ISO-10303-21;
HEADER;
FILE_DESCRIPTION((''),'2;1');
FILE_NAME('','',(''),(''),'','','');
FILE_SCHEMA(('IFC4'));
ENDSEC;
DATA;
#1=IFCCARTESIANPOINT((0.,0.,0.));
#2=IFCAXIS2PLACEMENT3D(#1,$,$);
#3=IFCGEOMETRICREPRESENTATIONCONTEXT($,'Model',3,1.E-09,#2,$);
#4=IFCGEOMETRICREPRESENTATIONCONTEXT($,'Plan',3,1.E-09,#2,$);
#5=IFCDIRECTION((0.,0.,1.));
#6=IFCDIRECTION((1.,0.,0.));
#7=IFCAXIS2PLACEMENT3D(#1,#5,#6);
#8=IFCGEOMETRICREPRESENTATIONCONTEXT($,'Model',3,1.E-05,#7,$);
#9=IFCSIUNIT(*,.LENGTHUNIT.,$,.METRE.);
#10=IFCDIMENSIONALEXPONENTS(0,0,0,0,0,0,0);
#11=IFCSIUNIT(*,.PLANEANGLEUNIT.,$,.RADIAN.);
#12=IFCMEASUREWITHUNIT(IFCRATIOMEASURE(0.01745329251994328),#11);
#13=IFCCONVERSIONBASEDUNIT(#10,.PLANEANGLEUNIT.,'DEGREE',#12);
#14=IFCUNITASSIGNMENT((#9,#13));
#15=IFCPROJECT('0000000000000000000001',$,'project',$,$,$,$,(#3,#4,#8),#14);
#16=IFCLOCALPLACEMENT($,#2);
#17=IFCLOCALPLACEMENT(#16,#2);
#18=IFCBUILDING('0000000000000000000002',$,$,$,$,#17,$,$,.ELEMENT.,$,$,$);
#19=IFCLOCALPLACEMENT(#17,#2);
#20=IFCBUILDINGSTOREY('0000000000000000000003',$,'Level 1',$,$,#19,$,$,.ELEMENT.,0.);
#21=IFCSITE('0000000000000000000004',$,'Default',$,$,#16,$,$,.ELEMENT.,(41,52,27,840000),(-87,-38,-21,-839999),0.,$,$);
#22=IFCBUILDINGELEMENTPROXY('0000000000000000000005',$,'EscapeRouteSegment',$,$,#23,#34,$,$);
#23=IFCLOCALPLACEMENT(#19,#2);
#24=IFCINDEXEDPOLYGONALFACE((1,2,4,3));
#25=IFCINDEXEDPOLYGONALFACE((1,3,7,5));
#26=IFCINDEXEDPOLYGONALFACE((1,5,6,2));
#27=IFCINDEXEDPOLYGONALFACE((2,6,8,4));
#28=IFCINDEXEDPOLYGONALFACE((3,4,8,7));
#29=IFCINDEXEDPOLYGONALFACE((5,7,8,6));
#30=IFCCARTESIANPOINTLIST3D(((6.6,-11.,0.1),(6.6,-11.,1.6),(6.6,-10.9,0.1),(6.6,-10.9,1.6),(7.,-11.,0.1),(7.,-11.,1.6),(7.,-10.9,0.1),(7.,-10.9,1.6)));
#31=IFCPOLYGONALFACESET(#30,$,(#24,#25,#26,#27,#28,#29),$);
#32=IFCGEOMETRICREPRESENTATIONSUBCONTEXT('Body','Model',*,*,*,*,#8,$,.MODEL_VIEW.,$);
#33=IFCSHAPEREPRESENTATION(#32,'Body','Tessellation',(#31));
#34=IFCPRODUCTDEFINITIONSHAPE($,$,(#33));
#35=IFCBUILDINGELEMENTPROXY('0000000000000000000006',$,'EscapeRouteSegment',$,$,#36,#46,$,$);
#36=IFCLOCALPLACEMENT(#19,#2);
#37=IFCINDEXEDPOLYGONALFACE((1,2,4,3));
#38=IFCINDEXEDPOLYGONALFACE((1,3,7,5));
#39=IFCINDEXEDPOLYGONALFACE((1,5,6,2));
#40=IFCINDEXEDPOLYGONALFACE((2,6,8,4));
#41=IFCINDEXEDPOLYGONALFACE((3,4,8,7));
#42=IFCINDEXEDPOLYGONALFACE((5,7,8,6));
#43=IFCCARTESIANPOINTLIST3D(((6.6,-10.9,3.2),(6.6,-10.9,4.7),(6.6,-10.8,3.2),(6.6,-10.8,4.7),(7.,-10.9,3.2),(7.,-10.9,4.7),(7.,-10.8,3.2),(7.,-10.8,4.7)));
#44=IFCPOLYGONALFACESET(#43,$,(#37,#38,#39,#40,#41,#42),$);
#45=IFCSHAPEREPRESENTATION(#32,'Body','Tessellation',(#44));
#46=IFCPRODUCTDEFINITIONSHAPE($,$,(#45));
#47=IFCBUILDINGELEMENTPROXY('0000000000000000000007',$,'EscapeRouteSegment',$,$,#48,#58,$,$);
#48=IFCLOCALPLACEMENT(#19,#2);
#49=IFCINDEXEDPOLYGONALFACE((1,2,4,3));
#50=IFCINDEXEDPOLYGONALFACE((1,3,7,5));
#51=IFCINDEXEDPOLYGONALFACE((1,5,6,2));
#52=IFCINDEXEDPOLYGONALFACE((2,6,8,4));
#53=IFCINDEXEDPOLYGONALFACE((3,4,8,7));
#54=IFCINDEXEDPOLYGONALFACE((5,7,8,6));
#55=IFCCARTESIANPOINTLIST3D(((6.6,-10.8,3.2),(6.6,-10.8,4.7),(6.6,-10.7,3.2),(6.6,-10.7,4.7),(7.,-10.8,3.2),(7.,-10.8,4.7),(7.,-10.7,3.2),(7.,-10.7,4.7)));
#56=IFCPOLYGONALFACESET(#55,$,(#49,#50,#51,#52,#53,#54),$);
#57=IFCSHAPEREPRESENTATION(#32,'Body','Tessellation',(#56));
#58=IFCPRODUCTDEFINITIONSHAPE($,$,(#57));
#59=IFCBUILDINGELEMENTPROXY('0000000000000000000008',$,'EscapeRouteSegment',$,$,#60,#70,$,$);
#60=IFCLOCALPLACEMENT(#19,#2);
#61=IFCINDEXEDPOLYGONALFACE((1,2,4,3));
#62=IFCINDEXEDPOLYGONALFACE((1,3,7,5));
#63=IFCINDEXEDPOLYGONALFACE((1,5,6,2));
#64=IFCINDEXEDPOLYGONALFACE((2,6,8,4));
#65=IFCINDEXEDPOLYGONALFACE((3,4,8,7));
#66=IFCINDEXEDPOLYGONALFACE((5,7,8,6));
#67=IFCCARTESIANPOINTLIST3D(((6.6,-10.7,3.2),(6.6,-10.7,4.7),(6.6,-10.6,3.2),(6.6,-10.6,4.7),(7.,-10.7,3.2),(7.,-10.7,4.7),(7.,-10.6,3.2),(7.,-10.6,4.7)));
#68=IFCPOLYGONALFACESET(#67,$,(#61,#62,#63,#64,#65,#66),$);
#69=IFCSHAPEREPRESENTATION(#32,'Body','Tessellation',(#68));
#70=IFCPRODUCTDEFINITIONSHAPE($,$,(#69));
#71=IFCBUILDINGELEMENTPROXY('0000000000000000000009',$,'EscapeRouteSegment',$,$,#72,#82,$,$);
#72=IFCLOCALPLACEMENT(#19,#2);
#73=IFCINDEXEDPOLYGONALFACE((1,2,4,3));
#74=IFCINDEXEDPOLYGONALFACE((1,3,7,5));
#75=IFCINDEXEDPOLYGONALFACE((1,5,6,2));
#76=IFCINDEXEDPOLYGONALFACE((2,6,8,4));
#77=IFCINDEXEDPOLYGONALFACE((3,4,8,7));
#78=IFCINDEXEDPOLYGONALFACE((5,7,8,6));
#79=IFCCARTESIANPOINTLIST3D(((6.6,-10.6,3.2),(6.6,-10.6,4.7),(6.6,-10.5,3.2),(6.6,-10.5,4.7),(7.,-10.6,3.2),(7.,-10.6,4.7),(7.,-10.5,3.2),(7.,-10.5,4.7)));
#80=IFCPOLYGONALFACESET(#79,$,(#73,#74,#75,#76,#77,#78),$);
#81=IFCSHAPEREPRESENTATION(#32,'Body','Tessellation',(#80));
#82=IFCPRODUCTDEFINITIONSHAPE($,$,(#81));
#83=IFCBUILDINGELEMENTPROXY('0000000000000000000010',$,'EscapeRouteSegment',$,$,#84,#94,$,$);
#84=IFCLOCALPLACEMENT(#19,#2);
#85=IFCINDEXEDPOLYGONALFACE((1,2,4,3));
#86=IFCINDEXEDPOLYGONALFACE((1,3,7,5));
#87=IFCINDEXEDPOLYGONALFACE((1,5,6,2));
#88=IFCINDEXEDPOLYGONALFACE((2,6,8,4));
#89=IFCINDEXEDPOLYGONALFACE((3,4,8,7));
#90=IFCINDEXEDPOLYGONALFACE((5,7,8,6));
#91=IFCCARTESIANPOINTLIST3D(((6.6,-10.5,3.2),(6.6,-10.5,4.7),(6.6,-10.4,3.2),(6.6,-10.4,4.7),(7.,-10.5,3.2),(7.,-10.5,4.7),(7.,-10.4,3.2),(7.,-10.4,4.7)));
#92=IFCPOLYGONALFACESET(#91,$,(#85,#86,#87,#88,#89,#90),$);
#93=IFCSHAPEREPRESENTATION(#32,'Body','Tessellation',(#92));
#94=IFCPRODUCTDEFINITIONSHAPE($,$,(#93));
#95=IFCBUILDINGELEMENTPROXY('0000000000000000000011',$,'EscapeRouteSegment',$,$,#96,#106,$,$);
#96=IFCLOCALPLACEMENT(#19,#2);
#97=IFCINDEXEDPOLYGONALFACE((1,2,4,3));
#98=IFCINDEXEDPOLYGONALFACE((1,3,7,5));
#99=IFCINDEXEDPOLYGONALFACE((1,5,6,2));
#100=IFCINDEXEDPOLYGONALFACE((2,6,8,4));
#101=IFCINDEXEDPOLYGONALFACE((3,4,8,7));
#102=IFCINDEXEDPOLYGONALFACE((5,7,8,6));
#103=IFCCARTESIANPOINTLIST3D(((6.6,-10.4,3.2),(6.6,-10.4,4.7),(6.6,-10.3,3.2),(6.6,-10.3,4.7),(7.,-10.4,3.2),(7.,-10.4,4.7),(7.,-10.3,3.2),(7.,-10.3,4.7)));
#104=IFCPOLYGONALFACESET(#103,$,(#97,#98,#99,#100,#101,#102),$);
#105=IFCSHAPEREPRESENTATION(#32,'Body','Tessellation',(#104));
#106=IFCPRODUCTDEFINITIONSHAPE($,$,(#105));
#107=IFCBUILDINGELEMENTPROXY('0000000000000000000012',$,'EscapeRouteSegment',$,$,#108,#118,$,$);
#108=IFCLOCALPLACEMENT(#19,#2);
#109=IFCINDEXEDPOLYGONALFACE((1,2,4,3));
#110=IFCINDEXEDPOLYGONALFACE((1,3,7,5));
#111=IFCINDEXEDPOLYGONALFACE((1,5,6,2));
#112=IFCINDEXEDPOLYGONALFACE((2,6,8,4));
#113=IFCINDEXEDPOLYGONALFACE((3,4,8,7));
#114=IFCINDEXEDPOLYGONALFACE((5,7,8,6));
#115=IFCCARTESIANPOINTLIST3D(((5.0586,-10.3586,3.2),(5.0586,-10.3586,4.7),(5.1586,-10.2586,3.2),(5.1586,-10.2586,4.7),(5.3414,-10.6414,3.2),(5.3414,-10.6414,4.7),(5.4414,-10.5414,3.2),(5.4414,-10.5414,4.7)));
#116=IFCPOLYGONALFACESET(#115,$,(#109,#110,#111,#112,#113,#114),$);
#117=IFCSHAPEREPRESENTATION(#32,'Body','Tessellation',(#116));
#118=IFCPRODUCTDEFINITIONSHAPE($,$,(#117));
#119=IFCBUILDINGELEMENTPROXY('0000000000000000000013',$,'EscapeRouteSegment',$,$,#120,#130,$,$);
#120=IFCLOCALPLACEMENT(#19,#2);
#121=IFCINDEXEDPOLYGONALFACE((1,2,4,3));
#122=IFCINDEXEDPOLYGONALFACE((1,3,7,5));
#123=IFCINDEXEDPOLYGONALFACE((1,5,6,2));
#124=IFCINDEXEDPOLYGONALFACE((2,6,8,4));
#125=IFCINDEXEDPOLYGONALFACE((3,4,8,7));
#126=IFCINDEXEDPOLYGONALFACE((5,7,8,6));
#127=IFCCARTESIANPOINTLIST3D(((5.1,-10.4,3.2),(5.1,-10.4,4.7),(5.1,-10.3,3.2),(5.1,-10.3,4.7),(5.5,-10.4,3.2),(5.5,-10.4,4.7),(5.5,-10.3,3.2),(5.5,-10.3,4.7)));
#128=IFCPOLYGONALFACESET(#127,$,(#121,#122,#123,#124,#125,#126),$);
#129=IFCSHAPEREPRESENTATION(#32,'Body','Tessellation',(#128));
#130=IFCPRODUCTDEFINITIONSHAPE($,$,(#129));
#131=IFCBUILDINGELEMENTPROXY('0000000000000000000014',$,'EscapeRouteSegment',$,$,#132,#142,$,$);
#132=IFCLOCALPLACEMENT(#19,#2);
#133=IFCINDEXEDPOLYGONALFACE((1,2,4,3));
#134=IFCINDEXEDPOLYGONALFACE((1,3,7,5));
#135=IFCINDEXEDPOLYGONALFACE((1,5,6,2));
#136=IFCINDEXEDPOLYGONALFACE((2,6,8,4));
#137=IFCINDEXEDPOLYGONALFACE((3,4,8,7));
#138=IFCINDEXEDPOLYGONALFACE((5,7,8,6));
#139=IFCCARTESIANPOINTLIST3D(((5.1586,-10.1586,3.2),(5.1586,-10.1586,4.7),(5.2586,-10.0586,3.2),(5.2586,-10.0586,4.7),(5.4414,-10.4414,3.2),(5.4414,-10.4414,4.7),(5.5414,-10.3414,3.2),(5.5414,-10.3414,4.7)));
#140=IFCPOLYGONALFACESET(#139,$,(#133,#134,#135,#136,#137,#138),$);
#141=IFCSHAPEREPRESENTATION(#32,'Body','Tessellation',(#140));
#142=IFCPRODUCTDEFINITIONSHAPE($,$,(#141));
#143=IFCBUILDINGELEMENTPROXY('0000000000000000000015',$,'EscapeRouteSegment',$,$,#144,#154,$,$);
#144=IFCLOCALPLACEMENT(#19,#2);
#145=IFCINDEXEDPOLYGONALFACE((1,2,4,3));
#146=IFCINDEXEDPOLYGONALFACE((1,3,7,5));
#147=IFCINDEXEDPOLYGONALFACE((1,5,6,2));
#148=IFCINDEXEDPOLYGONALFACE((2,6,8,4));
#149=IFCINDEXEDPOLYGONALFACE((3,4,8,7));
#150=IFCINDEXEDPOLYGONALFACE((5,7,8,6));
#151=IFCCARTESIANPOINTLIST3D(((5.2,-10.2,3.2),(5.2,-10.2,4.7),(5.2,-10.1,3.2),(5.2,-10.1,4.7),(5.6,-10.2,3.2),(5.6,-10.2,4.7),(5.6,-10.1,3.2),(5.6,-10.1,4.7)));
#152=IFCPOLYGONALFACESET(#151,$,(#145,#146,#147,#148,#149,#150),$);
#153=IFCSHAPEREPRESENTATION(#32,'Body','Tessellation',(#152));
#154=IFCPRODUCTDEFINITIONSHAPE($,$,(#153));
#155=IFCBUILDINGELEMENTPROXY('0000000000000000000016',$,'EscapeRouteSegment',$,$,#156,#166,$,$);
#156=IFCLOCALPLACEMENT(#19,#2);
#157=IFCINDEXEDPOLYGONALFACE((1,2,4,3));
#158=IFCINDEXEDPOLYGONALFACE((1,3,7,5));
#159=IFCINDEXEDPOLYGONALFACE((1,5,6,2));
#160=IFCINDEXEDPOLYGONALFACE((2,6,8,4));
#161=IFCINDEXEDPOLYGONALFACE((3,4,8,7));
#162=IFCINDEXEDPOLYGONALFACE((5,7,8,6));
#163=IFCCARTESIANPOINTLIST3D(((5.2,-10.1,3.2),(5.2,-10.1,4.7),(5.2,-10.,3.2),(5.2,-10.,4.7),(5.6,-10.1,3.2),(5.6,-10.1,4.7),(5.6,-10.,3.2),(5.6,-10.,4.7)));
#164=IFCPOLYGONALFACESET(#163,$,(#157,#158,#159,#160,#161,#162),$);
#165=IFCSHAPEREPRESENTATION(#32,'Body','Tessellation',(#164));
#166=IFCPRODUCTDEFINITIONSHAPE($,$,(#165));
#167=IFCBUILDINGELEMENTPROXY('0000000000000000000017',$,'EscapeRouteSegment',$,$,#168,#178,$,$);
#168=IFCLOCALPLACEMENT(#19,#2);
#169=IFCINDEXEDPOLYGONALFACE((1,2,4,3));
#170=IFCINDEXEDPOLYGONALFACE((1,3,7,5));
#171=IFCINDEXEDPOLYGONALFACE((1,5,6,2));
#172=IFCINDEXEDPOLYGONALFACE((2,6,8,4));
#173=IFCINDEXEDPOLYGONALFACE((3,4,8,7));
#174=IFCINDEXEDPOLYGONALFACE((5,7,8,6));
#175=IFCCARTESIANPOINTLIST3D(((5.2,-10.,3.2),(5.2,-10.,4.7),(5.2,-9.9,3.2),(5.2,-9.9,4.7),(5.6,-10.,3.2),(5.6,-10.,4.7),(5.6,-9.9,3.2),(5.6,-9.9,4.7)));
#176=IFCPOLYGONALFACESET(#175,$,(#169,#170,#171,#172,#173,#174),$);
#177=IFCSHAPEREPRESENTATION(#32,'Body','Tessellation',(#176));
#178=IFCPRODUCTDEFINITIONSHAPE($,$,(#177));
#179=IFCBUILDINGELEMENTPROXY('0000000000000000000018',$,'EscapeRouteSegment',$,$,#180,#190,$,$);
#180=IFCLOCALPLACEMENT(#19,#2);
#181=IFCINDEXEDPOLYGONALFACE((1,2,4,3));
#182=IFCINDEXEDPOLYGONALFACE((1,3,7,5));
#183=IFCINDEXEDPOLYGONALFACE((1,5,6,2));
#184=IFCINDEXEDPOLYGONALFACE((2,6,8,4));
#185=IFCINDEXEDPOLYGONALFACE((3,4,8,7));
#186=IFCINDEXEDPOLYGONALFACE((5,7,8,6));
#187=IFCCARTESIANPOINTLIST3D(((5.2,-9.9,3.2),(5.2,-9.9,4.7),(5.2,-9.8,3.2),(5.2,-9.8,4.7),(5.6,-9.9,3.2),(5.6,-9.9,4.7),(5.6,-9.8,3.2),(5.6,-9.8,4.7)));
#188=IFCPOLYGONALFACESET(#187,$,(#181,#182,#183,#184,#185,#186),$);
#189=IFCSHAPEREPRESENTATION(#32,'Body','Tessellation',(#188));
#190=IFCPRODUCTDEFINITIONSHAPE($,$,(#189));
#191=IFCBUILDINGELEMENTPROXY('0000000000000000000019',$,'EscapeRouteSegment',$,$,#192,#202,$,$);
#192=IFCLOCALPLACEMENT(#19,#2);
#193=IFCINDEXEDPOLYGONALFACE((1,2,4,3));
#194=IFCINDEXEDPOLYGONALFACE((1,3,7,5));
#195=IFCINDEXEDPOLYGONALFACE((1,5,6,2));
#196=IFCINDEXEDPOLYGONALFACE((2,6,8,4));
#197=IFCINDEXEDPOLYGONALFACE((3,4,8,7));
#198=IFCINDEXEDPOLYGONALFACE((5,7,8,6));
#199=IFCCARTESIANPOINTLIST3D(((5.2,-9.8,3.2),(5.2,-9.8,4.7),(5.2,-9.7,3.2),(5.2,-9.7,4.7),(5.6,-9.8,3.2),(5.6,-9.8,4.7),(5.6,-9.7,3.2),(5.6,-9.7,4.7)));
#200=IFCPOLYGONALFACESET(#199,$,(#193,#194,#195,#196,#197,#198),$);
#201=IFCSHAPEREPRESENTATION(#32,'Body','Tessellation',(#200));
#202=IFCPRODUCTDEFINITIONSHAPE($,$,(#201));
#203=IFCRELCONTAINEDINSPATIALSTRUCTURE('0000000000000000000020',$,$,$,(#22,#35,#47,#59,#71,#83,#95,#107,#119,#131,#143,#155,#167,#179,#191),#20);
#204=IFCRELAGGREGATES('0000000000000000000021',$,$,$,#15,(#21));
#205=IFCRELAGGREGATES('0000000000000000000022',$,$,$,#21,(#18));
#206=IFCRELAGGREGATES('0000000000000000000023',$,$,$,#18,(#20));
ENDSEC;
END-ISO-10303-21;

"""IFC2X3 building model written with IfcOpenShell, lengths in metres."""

from ifc_helpers import new_model, entity, si_unit, converted_unit, frame, origin, origin_with_axes, place, context, subcontext, project, spatial, polyline, outline, extrude, element, save


model = new_model("IFC2X3")

# Units and contexts
model_context_1 = context("Model", 3, precision=1e-09, world=origin())
plan_context = context("Plan", 3, precision=1e-09, world=origin())
model_context_2 = context("Model", 3, precision=1e-05, world=origin_with_axes())
body_context = subcontext(model_context_2, "Body", "Model", "MODEL_VIEW")
ifc_project = project(units=[si_unit("LENGTHUNIT", "METRE"), converted_unit("PLANEANGLEUNIT", "DEGREE", entity("IfcRatioMeasure", 0.01745329251994328), si_unit("PLANEANGLEUNIT", "RADIAN"), dimensions=[0, 0, 0, 0, 0, 0, 0])], contexts=[model_context_1, plan_context, model_context_2])

# Site, building, storey
site_placement = place(None, origin())
site = spatial("IfcSite", under=ifc_project, at=site_placement, Name="Default", CompositionType="ELEMENT", RefLatitude=(41, 52, 27, 840000), RefLongitude=(-87, -38, -21, -839999), RefElevation=0.0)
building_placement = place(site_placement, origin())
building = spatial("IfcBuilding", under=site, at=building_placement, CompositionType="ELEMENT")
storey_placement = place(building_placement, origin())
storey = spatial("IfcBuildingStorey", under=building, at=storey_placement, Name="Level 1", CompositionType="ELEMENT", Elevation=0.0)

# Building element proxies
proxy_1_placement = place(storey_placement, frame((6.8, -10.9, 0.1), z_axis=(0.0, 0.0, 1.0), x_axis=(0.0, -1.0, 0.0)))
element("IfcBuildingElementProxy", 1, at=proxy_1_placement, inside=storey, Name="EscapeRouteSegment", context=body_context, shape_type="SweptSolid", body=[
    extrude(outline(polyline([(0.0, -0.2), (0.0, 0.2), (0.1, 0.2), (0.1, -0.2), (0.0, -0.2)])), origin_with_axes(), (0.0, 0.0, 1.0), 1.5),
])
proxy_2_placement = place(storey_placement, frame((6.8, -10.9, 3.2), z_axis=(0.0, 0.0, 1.0), x_axis=(0.0, 1.0, 0.0)))
element("IfcBuildingElementProxy", 2, at=proxy_2_placement, inside=storey, Name="EscapeRouteSegment", context=body_context, shape_type="SweptSolid", body=[
    extrude(outline(polyline([(0.0, -0.2), (0.0, 0.2), (0.1, 0.2), (0.1, -0.2), (0.0, -0.2)])), origin_with_axes(), (0.0, 0.0, 1.0), 1.5),
])
proxy_3_placement = place(storey_placement, frame((6.8, -10.8, 3.2), z_axis=(0.0, 0.0, 1.0), x_axis=(0.0, 1.0, 0.0)))
element("IfcBuildingElementProxy", 3, at=proxy_3_placement, inside=storey, Name="EscapeRouteSegment", context=body_context, shape_type="SweptSolid", body=[
    extrude(outline(polyline([(0.0, -0.2), (0.0, 0.2), (0.1, 0.2), (0.1, -0.2), (0.0, -0.2)])), origin_with_axes(), (0.0, 0.0, 1.0), 1.5),
])
proxy_4_placement = place(storey_placement, frame((6.8, -10.7, 3.2), z_axis=(0.0, 0.0, 1.0), x_axis=(0.0, 1.0, 0.0)))
element("IfcBuildingElementProxy", 4, at=proxy_4_placement, inside=storey, Name="EscapeRouteSegment", context=body_context, shape_type="SweptSolid", body=[
    extrude(outline(polyline([(0.0, -0.2), (0.0, 0.2), (0.1, 0.2), (0.1, -0.2), (0.0, -0.2)])), origin_with_axes(), (0.0, 0.0, 1.0), 1.5),
])
for number, where, z_axis, x_axis, name in (
    (5, (6.8, -10.6, 3.2), (0.0, 0.0, 1.0), (0.0, 1.0, 0.0), "EscapeRouteSegment"),
    (6, (6.8, -10.5, 3.2), (0.0, 0.0, 1.0), (0.0, 1.0, 0.0), "EscapeRouteSegment"),
):
    element("IfcBuildingElementProxy", number, at=place(storey_placement, frame(where, z_axis=z_axis, x_axis=x_axis)), inside=storey, Name=name, context=body_context, shape_type="SweptSolid", body=[
        extrude(outline(polyline([(0.0, -0.2), (0.0, 0.2), (0.1, 0.2), (0.1, -0.2), (0.0, -0.2)])), origin_with_axes(), (0.0, 0.0, 1.0), 1.5),
    ])
proxy_5_placement = place(storey_placement, frame((6.8, -10.4, 3.2), z_axis=(0.0, 0.0, 1.0), x_axis=(0.0, 1.0, 0.0)))
element("IfcBuildingElementProxy", 7, at=proxy_5_placement, inside=storey, Name="EscapeRouteSegment", context=body_context, shape_type="SweptSolid", body=[
    extrude(outline(polyline([(0.0, -0.2), (0.0, 0.2), (0.1, 0.2), (0.1, -0.2), (0.0, -0.2)])), origin_with_axes(), (0.0, 0.0, 1.0), 1.5),
])
proxy_6_placement = place(storey_placement, frame((5.2, -10.5, 3.2), z_axis=(0.0, 0.0, 1.0), x_axis=(0.707107, 0.707107, 0.0)))
element("IfcBuildingElementProxy", 8, at=proxy_6_placement, inside=storey, Name="EscapeRouteSegment", context=body_context, shape_type="SweptSolid", body=[
    extrude(outline(polyline([(0.0, -0.2), (0.0, 0.2), (0.1414, 0.2), (0.1414, -0.2), (0.0, -0.2)])), origin_with_axes(), (0.0, 0.0, 1.0), 1.5),
])
proxy_7_placement = place(storey_placement, frame((5.3, -10.4, 3.2), z_axis=(0.0, 0.0, 1.0), x_axis=(0.0, 1.0, 0.0)))
element("IfcBuildingElementProxy", 9, at=proxy_7_placement, inside=storey, Name="EscapeRouteSegment", context=body_context, shape_type="SweptSolid", body=[
    extrude(outline(polyline([(0.0, -0.2), (0.0, 0.2), (0.1, 0.2), (0.1, -0.2), (0.0, -0.2)])), origin_with_axes(), (0.0, 0.0, 1.0), 1.5),
])
proxy_8_placement = place(storey_placement, frame((5.3, -10.3, 3.2), z_axis=(0.0, 0.0, 1.0), x_axis=(0.707105, 0.707108, 0.0)))
element("IfcBuildingElementProxy", 10, at=proxy_8_placement, inside=storey, Name="EscapeRouteSegment", context=body_context, shape_type="SweptSolid", body=[
    extrude(outline(polyline([(0.0, -0.2), (0.0, 0.2), (0.1414, 0.2), (0.1414, -0.2), (0.0, -0.2)])), origin_with_axes(), (0.0, 0.0, 1.0), 1.5),
])
proxy_9_placement = place(storey_placement, frame((5.4, -10.2, 3.2), z_axis=(0.0, 0.0, 1.0), x_axis=(0.0, 1.0, 0.0)))
element("IfcBuildingElementProxy", 11, at=proxy_9_placement, inside=storey, Name="EscapeRouteSegment", context=body_context, shape_type="SweptSolid", body=[
    extrude(outline(polyline([(0.0, -0.2), (0.0, 0.2), (0.1, 0.2), (0.1, -0.2), (0.0, -0.2)])), origin_with_axes(), (0.0, 0.0, 1.0), 1.5),
])
for number, where, z_axis, x_axis, name in (
    (12, (5.4, -10.1, 3.2), (0.0, 0.0, 1.0), (0.0, 1.0, 0.0), "EscapeRouteSegment"),
    (13, (5.4, -10.0, 3.2), (0.0, 0.0, 1.0), (0.0, 1.0, 0.0), "EscapeRouteSegment"),
):
    element("IfcBuildingElementProxy", number, at=place(storey_placement, frame(where, z_axis=z_axis, x_axis=x_axis)), inside=storey, Name=name, context=body_context, shape_type="SweptSolid", body=[
        extrude(outline(polyline([(0.0, -0.2), (0.0, 0.2), (0.1, 0.2), (0.1, -0.2), (0.0, -0.2)])), origin_with_axes(), (0.0, 0.0, 1.0), 1.5),
    ])
proxy_10_placement = place(storey_placement, frame((5.4, -9.9, 3.2), z_axis=(0.0, 0.0, 1.0), x_axis=(0.0, 1.0, 0.0)))
element("IfcBuildingElementProxy", 14, at=proxy_10_placement, inside=storey, Name="EscapeRouteSegment", context=body_context, shape_type="SweptSolid", body=[
    extrude(outline(polyline([(0.0, -0.2), (0.0, 0.2), (0.1, 0.2), (0.1, -0.2), (0.0, -0.2)])), origin_with_axes(), (0.0, 0.0, 1.0), 1.5),
])
proxy_11_placement = place(storey_placement, frame((5.4, -9.8, 3.2), z_axis=(0.0, 0.0, 1.0), x_axis=(0.0, 1.0, 0.0)))
element("IfcBuildingElementProxy", 15, at=proxy_11_placement, inside=storey, Name="EscapeRouteSegment", context=body_context, shape_type="SweptSolid", body=[
    extrude(outline(polyline([(0.0, -0.2), (0.0, 0.2), (0.1, 0.2), (0.1, -0.2), (0.0, -0.2)])), origin_with_axes(), (0.0, 0.0, 1.0), 1.5),
])

save(model, "model.ifc")
